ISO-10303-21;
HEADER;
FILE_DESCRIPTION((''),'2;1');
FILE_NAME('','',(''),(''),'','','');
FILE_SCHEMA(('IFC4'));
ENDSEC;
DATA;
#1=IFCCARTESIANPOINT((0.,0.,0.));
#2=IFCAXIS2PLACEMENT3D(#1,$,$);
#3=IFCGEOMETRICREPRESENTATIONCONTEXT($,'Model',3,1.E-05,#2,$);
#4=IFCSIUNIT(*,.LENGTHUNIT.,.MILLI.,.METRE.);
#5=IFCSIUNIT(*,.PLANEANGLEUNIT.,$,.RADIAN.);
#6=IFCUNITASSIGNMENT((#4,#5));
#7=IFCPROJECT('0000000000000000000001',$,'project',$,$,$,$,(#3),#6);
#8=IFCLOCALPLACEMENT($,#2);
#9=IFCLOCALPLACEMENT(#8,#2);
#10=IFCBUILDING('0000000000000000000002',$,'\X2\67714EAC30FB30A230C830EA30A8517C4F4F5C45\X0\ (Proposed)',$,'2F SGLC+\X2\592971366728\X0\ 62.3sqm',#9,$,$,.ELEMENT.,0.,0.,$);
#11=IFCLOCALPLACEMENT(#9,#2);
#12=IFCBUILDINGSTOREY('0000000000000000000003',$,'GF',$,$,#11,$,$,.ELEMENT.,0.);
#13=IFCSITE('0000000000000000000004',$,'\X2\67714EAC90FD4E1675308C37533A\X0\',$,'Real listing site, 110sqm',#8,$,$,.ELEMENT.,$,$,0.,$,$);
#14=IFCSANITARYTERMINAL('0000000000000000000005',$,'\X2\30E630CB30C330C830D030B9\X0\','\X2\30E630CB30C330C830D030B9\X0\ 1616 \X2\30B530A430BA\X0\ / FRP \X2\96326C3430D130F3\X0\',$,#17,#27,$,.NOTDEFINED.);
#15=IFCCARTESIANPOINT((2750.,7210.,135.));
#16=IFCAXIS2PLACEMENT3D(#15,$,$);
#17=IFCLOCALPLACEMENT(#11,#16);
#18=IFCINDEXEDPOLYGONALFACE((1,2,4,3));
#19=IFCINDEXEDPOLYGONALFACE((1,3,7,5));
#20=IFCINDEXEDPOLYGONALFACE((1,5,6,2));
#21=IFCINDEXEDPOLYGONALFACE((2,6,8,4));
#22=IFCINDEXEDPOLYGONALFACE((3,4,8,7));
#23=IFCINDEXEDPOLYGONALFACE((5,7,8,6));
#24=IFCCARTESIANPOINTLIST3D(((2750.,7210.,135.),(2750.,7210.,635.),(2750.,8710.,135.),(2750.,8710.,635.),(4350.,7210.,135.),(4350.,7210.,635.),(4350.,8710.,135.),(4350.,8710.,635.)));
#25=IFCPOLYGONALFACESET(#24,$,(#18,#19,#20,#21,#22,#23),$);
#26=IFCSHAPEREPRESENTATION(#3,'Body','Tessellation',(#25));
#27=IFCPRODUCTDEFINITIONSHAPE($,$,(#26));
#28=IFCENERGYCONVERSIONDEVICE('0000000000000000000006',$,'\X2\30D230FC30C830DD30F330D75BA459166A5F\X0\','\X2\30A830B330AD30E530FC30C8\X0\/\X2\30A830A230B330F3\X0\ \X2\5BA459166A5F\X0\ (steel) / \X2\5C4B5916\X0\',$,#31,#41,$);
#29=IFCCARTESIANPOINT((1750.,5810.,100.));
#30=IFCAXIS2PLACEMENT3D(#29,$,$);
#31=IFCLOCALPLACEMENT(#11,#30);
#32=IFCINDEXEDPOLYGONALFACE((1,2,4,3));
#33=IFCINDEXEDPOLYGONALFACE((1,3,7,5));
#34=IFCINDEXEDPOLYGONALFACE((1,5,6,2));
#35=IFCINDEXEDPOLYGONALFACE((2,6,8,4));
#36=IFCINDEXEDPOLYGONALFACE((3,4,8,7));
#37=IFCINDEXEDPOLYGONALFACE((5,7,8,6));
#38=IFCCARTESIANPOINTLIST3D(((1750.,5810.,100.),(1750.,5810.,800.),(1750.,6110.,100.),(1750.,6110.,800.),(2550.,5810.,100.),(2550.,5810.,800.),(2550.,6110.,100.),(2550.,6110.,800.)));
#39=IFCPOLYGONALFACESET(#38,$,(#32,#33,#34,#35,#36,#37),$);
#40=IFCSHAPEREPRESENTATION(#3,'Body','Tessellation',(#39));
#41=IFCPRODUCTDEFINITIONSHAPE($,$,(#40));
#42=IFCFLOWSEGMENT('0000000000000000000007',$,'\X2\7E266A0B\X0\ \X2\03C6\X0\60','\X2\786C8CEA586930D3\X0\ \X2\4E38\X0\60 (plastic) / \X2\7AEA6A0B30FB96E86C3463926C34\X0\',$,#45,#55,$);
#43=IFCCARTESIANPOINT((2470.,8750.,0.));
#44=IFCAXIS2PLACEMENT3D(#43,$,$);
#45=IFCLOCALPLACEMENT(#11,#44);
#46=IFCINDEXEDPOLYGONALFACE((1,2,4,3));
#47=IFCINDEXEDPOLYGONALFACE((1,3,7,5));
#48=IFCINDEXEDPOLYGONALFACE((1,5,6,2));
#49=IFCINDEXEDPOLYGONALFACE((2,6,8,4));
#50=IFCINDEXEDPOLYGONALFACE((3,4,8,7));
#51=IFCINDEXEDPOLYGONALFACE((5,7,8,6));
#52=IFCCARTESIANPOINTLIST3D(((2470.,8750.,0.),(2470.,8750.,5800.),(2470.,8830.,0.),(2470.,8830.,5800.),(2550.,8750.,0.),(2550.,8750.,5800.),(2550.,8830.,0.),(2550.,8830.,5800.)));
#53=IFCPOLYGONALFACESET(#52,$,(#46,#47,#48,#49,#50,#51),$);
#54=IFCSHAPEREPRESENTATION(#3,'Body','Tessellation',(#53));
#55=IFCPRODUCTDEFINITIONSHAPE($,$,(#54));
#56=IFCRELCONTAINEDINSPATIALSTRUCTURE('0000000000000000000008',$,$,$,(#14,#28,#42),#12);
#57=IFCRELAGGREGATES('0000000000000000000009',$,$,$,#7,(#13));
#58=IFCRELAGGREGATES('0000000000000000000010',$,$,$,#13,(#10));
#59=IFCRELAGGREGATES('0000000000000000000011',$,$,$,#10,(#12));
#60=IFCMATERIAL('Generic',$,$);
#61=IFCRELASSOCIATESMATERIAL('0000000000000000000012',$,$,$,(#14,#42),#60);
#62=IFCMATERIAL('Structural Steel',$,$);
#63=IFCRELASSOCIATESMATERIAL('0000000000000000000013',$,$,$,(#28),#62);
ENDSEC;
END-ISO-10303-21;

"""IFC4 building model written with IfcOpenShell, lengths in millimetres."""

from ifc_helpers import new_model, si_unit, frame, frame_2d, origin, place, context, project, spatial, rectangle, extrude, material, element, save


model = new_model("IFC4")

# Units and contexts
model_context = context("Model", 3, precision=1e-05, world=origin())
ifc_project = project(units=[si_unit("LENGTHUNIT", "METRE", prefix="MILLI"), si_unit("PLANEANGLEUNIT", "RADIAN")], contexts=[model_context])

# Site, building, storey
site_placement = place(None, origin())
site = spatial("IfcSite", under=ifc_project, at=site_placement, Name="東京都世田谷区", ObjectType="Real listing site, 110sqm", CompositionType="ELEMENT", RefElevation=0.0)
building_placement = place(site_placement, origin())
building = spatial("IfcBuilding", under=site, at=building_placement, Name="東京・アトリエ兼住居 (Proposed)", ObjectType="2F SGLC+天然木 62.3sqm", CompositionType="ELEMENT", ElevationOfRefHeight=0.0, ElevationOfTerrain=0.0)
storey_placement = place(building_placement, origin())
storey = spatial("IfcBuildingStorey", under=building, at=storey_placement, Name="GF", CompositionType="ELEMENT", Elevation=0.0)

# Shared definitions
ifc_material_1 = material(Name="Generic")

# Sanitary terminal
sanitary_terminal_placement = place(storey_placement, frame((2750.0, 7210.0, 135.0)))
element("IfcSanitaryTerminal", 1, at=sanitary_terminal_placement, inside=storey, material=ifc_material_1, Name="ユニットバス", Description="ユニットバス 1616 サイズ / FRP 防水パン", PredefinedType="NOTDEFINED", context=model_context, shape_type="SweptSolid", body=[
    extrude(rectangle(XDim=1600.0, YDim=1500.0, at=frame_2d((800.0, 750.0))), frame((2750.0, 7210.0, 135.0)), (0.0, 0.0, 1.0), 500.0),
])

# Energy conversion device
ifc_material_2 = material(Name="Structural Steel")
energy_conversion_device_placement = place(storey_placement, frame((1750.0, 5810.0, 100.0)))
element("IfcEnergyConversionDevice", 2, at=energy_conversion_device_placement, inside=storey, material=ifc_material_2, Name="ヒートポンプ室外機", Description="エコキュート/エアコン 室外機 (steel) / 屋外", context=model_context, shape_type="SweptSolid", body=[
    extrude(rectangle(XDim=800.0, YDim=300.0, at=frame_2d((400.0, 150.0))), frame((1750.0, 5810.0, 100.0)), (0.0, 0.0, 1.0), 700.0),
])

# Flow segment
flow_segment_placement = place(storey_placement, frame((2470.0, 8750.0, 0.0)))
element("IfcFlowSegment", 3, at=flow_segment_placement, inside=storey, material=ifc_material_1, Name="縦樋 φ60", Description="硬質塩ビ 丸60 (plastic) / 竪樋・雨水排水", context=model_context, shape_type="SweptSolid", body=[
    extrude(rectangle(XDim=80.0, YDim=80.0, at=frame_2d((40.0, 40.0))), frame((2470.0, 8750.0, 0.0)), (0.0, 0.0, 1.0), 5800.0),
])

save(model, "model.ifc")
